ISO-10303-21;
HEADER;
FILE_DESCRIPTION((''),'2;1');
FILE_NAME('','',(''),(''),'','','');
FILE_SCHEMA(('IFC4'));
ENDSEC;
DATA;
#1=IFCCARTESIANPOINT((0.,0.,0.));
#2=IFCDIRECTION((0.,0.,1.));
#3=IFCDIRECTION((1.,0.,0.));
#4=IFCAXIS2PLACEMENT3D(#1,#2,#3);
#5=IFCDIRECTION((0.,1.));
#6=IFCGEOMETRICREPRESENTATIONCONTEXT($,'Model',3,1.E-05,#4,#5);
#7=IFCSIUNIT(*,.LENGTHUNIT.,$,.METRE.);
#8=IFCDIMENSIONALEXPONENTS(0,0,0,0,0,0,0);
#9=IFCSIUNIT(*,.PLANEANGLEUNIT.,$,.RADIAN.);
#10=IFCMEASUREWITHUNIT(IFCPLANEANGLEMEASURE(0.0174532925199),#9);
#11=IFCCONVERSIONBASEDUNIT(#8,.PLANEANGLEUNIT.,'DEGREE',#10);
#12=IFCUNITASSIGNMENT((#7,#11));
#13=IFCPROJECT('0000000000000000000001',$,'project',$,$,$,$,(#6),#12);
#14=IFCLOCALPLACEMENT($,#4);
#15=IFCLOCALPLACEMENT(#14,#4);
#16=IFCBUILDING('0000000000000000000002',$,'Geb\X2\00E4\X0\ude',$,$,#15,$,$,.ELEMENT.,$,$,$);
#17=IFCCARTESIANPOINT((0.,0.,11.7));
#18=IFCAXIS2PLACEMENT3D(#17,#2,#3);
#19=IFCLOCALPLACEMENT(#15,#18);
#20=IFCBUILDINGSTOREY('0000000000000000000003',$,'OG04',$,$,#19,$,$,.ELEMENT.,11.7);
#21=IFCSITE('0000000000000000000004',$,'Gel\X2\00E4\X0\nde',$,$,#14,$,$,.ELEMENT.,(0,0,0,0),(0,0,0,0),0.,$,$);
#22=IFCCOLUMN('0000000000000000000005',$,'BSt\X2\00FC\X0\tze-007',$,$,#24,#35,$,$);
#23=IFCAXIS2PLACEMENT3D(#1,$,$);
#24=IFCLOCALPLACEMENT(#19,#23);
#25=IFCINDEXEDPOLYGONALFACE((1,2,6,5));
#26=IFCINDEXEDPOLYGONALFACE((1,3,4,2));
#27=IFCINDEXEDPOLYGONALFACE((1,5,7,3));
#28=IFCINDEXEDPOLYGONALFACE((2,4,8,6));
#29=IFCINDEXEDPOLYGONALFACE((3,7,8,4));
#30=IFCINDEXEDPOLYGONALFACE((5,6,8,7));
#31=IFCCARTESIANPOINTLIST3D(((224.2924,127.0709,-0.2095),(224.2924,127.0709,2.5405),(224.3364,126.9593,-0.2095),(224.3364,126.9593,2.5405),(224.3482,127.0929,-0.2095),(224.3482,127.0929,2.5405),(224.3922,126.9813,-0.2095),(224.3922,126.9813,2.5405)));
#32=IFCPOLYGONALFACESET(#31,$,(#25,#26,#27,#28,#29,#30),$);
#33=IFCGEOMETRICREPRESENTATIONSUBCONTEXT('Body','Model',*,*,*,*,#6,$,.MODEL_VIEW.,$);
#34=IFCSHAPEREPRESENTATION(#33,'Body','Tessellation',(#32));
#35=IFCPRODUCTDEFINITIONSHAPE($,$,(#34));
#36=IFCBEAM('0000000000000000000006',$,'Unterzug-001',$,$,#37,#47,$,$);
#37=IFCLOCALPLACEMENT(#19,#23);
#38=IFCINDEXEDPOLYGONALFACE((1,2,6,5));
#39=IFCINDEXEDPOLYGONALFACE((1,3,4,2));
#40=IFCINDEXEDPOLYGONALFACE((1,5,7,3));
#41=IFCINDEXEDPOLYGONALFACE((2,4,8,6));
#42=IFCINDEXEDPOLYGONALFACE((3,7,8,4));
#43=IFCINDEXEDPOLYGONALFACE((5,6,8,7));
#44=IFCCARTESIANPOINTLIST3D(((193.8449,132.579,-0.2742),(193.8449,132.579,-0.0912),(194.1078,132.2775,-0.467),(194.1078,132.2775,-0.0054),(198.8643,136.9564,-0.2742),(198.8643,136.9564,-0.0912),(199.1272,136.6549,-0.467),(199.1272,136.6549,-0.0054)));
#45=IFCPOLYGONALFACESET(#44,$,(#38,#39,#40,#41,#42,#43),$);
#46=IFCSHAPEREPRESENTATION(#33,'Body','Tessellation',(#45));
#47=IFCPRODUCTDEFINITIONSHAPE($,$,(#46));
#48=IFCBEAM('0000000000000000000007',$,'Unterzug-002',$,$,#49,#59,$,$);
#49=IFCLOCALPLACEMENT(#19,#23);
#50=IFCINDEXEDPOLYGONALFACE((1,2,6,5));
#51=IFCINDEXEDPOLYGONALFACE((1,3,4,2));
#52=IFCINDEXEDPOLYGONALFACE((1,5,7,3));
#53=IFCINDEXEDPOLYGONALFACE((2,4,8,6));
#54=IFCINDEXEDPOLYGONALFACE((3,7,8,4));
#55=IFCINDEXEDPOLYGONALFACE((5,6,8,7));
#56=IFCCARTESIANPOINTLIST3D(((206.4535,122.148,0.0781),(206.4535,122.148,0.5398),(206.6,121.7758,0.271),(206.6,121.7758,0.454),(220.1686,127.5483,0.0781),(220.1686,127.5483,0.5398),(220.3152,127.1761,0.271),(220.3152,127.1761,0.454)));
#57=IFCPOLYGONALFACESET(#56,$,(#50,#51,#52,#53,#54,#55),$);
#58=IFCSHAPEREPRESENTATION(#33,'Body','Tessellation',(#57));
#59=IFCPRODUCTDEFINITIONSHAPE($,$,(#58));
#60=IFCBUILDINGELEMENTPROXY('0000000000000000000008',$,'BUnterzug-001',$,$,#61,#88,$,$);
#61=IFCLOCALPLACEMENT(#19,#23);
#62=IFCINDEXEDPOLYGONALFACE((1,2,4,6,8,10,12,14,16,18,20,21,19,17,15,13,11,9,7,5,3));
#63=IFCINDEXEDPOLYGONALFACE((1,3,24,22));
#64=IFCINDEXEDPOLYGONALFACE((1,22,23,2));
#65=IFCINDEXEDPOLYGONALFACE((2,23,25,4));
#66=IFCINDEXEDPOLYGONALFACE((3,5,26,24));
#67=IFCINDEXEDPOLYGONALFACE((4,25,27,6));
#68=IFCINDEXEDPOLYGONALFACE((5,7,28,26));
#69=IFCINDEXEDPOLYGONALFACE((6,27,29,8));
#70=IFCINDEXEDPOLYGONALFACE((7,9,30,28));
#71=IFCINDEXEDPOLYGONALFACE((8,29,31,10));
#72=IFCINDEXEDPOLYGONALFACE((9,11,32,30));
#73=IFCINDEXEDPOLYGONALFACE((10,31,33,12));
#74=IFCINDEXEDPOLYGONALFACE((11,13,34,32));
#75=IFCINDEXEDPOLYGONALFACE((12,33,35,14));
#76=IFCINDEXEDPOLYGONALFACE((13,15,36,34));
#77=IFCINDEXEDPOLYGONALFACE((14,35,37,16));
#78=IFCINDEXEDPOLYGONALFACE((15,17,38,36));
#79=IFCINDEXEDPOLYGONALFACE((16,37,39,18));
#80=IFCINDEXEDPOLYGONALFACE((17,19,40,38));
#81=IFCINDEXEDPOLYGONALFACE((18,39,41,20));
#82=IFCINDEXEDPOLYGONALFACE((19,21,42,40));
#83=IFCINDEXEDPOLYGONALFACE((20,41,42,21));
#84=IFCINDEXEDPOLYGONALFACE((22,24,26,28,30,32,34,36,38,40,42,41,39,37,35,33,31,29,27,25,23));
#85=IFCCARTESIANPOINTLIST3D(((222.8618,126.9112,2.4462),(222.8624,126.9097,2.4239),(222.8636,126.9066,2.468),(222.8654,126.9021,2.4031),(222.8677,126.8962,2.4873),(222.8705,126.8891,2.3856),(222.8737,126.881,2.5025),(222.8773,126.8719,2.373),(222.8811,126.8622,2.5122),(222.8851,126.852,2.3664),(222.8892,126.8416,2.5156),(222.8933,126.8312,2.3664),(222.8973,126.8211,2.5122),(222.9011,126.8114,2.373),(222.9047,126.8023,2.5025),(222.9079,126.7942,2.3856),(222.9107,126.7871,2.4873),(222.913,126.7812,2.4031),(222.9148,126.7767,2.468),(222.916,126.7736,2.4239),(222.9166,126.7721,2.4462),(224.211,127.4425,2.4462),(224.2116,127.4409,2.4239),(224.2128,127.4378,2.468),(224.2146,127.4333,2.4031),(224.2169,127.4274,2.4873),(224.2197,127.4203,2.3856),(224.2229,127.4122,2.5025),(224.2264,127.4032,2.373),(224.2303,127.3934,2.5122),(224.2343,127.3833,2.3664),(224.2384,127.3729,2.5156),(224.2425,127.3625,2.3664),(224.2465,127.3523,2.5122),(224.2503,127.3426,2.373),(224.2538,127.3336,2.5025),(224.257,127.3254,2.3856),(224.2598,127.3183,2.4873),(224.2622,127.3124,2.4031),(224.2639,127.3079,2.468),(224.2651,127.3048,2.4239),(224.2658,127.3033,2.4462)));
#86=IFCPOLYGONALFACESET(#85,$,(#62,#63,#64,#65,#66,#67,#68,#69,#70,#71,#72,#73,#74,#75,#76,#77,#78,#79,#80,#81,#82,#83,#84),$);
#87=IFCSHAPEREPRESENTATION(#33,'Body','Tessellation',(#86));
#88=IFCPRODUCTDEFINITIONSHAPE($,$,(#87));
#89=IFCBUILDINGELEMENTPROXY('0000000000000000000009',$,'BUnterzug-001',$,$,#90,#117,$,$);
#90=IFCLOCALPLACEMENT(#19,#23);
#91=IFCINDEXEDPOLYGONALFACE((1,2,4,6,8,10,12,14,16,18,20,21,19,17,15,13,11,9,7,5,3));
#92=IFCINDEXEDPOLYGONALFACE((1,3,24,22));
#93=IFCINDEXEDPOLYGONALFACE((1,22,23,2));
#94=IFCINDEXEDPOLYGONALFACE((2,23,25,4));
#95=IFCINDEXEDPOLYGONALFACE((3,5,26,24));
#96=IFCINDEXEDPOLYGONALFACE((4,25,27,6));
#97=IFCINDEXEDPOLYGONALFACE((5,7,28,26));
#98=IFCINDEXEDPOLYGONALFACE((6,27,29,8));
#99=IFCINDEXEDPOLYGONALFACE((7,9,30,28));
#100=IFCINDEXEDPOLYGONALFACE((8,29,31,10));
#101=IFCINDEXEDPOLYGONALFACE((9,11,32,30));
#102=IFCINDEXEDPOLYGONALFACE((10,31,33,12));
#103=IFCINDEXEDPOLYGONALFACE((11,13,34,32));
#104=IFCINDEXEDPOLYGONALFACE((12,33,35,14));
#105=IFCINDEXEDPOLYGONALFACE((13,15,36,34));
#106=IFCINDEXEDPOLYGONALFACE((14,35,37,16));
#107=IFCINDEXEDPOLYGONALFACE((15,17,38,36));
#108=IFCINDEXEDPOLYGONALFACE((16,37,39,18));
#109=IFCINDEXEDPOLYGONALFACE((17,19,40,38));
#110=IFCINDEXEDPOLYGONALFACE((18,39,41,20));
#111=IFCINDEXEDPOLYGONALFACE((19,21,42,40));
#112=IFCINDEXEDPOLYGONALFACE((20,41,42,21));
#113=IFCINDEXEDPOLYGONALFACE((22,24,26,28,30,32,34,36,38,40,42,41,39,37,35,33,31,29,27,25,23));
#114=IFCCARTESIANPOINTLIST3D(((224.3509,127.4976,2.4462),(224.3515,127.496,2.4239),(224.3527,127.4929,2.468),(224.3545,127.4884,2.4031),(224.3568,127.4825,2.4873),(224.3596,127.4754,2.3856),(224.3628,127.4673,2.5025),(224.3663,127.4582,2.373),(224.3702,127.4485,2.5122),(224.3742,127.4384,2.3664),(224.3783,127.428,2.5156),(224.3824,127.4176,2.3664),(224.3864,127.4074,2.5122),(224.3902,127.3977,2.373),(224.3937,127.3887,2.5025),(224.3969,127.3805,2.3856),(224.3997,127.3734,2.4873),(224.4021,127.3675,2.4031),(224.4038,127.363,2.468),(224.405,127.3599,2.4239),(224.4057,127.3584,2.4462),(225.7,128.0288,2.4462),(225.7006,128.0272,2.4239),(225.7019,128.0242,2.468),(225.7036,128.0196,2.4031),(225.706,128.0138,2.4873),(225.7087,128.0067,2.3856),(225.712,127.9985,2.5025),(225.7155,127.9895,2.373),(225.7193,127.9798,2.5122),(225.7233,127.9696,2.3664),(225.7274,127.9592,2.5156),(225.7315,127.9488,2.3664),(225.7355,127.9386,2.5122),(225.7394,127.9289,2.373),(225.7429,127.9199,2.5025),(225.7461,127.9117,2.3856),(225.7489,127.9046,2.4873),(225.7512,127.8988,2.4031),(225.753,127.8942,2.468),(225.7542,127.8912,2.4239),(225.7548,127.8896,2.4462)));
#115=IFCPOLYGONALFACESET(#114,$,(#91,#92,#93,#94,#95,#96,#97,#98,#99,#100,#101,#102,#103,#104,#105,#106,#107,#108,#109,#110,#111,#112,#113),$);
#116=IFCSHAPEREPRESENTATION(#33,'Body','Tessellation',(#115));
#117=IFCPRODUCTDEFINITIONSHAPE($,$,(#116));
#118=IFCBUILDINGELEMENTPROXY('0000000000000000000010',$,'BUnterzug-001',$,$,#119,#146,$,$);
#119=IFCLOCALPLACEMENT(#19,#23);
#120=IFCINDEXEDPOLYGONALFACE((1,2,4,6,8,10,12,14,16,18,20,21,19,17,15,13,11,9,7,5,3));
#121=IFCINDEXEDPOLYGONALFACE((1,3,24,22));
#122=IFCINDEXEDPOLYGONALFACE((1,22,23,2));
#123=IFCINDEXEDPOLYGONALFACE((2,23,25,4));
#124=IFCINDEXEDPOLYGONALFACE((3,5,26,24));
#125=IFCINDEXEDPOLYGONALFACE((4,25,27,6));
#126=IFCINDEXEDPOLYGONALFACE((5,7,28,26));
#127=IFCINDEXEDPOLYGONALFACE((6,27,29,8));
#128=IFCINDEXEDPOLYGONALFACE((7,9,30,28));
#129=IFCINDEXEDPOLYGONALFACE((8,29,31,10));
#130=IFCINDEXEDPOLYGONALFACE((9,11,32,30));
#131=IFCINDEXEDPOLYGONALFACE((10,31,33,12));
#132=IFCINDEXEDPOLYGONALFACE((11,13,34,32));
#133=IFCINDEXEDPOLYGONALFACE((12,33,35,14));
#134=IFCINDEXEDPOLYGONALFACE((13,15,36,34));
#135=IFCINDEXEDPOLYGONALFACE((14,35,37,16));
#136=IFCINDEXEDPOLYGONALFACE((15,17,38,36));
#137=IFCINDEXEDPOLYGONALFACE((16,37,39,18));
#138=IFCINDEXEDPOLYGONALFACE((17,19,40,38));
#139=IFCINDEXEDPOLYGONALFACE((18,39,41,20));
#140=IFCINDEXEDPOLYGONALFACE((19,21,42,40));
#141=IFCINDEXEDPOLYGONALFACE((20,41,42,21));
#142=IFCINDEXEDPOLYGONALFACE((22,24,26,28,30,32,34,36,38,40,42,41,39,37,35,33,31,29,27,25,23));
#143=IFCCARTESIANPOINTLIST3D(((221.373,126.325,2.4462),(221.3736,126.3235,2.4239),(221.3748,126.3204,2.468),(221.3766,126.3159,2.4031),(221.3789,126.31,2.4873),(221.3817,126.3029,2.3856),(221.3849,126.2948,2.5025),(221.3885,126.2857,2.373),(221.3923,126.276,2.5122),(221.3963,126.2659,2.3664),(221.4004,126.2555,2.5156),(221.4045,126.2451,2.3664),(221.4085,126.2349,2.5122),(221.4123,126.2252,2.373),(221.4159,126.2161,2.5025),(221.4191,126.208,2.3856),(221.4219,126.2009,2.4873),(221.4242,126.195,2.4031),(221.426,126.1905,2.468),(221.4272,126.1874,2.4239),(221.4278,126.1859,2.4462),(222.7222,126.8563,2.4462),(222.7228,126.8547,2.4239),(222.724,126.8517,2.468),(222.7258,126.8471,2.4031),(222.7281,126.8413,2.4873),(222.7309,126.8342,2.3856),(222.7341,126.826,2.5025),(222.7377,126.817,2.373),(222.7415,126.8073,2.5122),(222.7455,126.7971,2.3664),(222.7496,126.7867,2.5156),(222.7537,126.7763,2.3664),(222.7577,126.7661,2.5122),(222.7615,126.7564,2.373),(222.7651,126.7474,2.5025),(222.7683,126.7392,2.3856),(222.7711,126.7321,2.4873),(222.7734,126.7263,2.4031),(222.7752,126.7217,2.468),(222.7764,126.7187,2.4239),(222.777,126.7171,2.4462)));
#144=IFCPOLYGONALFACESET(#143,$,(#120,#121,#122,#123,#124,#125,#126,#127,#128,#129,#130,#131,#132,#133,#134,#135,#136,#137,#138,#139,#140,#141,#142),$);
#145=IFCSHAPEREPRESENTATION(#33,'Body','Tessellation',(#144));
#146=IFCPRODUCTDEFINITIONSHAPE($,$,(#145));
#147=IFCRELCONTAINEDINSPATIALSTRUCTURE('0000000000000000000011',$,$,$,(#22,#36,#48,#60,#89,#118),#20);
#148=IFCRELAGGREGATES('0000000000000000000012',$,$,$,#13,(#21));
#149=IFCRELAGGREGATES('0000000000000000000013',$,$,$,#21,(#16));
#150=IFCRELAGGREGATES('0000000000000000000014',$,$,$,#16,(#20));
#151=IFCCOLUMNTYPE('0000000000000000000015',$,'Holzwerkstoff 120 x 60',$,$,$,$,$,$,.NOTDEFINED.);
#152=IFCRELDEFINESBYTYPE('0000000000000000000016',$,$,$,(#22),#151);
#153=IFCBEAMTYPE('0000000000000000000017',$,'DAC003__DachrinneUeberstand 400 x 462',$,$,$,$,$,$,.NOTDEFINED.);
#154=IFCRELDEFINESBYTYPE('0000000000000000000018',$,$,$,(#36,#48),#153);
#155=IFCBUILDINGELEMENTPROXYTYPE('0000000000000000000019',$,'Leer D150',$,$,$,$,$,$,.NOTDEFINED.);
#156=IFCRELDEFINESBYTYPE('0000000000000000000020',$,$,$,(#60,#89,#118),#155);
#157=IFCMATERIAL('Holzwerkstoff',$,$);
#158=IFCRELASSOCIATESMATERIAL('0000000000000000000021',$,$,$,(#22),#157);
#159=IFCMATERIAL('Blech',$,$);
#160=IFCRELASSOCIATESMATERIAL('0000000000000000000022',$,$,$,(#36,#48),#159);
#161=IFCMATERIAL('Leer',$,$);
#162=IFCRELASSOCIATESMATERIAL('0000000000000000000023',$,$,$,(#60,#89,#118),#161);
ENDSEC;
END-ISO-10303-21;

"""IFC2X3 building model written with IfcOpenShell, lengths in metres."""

from ifc_helpers import new_model, entity, si_unit, converted_unit, direction, frame, frame_2d, origin_with_axes, origin_2d_with_axis, place, context, subcontext, project, spatial, polyline, rectangle, circle, outline, extrude, material, type_object, element, save


model = new_model("IFC2X3")

# Units and contexts
model_context = context("Model", 3, precision=1e-05, world=origin_with_axes(), true_north=direction((0.0, 1.0)))
body_context = subcontext(model_context, "Body", "Model", "MODEL_VIEW")
ifc_project = project(units=[si_unit("LENGTHUNIT", "METRE"), converted_unit("PLANEANGLEUNIT", "DEGREE", entity("IfcPlaneAngleMeasure", 0.0174532925199), si_unit("PLANEANGLEUNIT", "RADIAN"), dimensions=[0, 0, 0, 0, 0, 0, 0])], contexts=[model_context])

# Site, building, storey
site_placement = place(None, origin_with_axes())
site = spatial("IfcSite", under=ifc_project, at=site_placement, Name="Gelände", CompositionType="ELEMENT", RefLatitude=(0, 0, 0, 0), RefLongitude=(0, 0, 0, 0), RefElevation=0.0)
building_placement = place(site_placement, origin_with_axes())
building = spatial("IfcBuilding", under=site, at=building_placement, Name="Gebäude", CompositionType="ELEMENT")
storey_placement = place(building_placement, frame((0.0, 0.0, 11.7), z_axis=(0.0, 0.0, 1.0), x_axis=(1.0, 0.0, 0.0)))
storey = spatial("IfcBuildingStorey", under=building, at=storey_placement, Name="OG04", CompositionType="ELEMENT", Elevation=11.7)

# Column
ifc_material_1 = material(Name="Holzwerkstoff")
column_type_1 = type_object("IfcColumnType", Name="Holzwerkstoff 120 x 60", PredefinedType="NOTDEFINED")
column_1_placement = place(storey_placement, frame((224.3423, 127.0261, -0.2095), z_axis=(0.0, 0.0, 1.0), x_axis=(0.366369, -0.93047, 0.0)))
element("IfcColumn", 1, at=column_1_placement, inside=storey, type_object=column_type_1, material=ifc_material_1, Name="BStütze-007", context=body_context, shape_type="SweptSolid", body=[
    extrude(rectangle(XDim=0.12, YDim=0.06, at=origin_2d_with_axis()), origin_with_axes(), (0.0, 0.0, 1.0), 2.75),
])

# Beams
ifc_material_2 = material(Name="Blech")
beam_type = type_object("IfcBeamType", Name="DAC003__DachrinneUeberstand 400 x 462", PredefinedType="NOTDEFINED")
beam_1_placement = place(storey_placement, frame((199.1272, 136.6549, -0.0054), z_axis=(0.0, 0.0, 1.0), x_axis=(-0.657268, 0.753657, 0.0)))
element("IfcBeam", 2, at=beam_1_placement, inside=storey, type_object=beam_type, material=ifc_material_2, Name="Unterzug-001", context=body_context, shape_type="SweptSolid", body=[
    extrude(outline(polyline([(0.0, 0.0), (-0.4, -0.0858), (-0.4, -0.2688), (0.0, -0.4616), (0.0, 0.0)])), frame((0.0, 6.66, 0.0), z_axis=(0.0, 1.0, 0.0), x_axis=(-1.0, 0.0, 0.0)), (0.0, 0.0, -1.0), 6.66),
])
beam_2_placement = place(storey_placement, frame((220.1686, 127.5483, 0.5398), z_axis=(0.0, 0.0, 1.0), x_axis=(-0.366369, 0.93047, 0.0)))
element("IfcBeam", 3, at=beam_2_placement, inside=storey, type_object=beam_type, material=ifc_material_2, Name="Unterzug-002", context=body_context, shape_type="SweptSolid", body=[
    extrude(outline(polyline([(0.0, 0.0), (-0.4, -0.0858), (-0.4, -0.2688), (0.0, -0.4616), (0.0, 0.0)])), frame((0.0, 14.74, 0.0), z_axis=(0.0, -1.0, 0.0), x_axis=(1.0, 0.0, 0.0)), (0.0, 0.0, 1.0), 14.74),
])

# Building element proxies
ifc_material_3 = material(Name="Leer")
building_element_proxy_type_1 = type_object("IfcBuildingElementProxyType", Name="Leer D150", PredefinedType="NOTDEFINED")
for number, where, z_axis, x_axis, name in (
    (4, (222.8892, 126.8416, 2.5156), (0.0, 0.0, 1.0), (0.366369, -0.93047, 0.0), "BUnterzug-001"),
    (5, (224.3783, 127.428, 2.5156), (0.0, 0.0, 1.0), (0.366369, -0.93047, 0.0), "BUnterzug-001"),
    (6, (221.4004, 126.2555, 2.5156), (0.0, 0.0, 1.0), (0.366369, -0.93047, 0.0), "BUnterzug-001"),
):
    element("IfcBuildingElementProxy", number, at=place(storey_placement, frame(where, z_axis=z_axis, x_axis=x_axis)), inside=storey, type_object=building_element_proxy_type_1, material=ifc_material_3, Name=name, context=body_context, shape_type="SweptSolid", body=[
        extrude(circle(Radius=0.075, at=frame_2d((-0.075, 0.0), x_axis=(1.0, 0.0))), frame((0.0, 0.0, 0.0), z_axis=(0.0, 1.0, 0.0), x_axis=(0.0, 0.0, 1.0)), (0.0, 0.0, 1.0), 1.45),
    ])

save(model, "model.ifc")
